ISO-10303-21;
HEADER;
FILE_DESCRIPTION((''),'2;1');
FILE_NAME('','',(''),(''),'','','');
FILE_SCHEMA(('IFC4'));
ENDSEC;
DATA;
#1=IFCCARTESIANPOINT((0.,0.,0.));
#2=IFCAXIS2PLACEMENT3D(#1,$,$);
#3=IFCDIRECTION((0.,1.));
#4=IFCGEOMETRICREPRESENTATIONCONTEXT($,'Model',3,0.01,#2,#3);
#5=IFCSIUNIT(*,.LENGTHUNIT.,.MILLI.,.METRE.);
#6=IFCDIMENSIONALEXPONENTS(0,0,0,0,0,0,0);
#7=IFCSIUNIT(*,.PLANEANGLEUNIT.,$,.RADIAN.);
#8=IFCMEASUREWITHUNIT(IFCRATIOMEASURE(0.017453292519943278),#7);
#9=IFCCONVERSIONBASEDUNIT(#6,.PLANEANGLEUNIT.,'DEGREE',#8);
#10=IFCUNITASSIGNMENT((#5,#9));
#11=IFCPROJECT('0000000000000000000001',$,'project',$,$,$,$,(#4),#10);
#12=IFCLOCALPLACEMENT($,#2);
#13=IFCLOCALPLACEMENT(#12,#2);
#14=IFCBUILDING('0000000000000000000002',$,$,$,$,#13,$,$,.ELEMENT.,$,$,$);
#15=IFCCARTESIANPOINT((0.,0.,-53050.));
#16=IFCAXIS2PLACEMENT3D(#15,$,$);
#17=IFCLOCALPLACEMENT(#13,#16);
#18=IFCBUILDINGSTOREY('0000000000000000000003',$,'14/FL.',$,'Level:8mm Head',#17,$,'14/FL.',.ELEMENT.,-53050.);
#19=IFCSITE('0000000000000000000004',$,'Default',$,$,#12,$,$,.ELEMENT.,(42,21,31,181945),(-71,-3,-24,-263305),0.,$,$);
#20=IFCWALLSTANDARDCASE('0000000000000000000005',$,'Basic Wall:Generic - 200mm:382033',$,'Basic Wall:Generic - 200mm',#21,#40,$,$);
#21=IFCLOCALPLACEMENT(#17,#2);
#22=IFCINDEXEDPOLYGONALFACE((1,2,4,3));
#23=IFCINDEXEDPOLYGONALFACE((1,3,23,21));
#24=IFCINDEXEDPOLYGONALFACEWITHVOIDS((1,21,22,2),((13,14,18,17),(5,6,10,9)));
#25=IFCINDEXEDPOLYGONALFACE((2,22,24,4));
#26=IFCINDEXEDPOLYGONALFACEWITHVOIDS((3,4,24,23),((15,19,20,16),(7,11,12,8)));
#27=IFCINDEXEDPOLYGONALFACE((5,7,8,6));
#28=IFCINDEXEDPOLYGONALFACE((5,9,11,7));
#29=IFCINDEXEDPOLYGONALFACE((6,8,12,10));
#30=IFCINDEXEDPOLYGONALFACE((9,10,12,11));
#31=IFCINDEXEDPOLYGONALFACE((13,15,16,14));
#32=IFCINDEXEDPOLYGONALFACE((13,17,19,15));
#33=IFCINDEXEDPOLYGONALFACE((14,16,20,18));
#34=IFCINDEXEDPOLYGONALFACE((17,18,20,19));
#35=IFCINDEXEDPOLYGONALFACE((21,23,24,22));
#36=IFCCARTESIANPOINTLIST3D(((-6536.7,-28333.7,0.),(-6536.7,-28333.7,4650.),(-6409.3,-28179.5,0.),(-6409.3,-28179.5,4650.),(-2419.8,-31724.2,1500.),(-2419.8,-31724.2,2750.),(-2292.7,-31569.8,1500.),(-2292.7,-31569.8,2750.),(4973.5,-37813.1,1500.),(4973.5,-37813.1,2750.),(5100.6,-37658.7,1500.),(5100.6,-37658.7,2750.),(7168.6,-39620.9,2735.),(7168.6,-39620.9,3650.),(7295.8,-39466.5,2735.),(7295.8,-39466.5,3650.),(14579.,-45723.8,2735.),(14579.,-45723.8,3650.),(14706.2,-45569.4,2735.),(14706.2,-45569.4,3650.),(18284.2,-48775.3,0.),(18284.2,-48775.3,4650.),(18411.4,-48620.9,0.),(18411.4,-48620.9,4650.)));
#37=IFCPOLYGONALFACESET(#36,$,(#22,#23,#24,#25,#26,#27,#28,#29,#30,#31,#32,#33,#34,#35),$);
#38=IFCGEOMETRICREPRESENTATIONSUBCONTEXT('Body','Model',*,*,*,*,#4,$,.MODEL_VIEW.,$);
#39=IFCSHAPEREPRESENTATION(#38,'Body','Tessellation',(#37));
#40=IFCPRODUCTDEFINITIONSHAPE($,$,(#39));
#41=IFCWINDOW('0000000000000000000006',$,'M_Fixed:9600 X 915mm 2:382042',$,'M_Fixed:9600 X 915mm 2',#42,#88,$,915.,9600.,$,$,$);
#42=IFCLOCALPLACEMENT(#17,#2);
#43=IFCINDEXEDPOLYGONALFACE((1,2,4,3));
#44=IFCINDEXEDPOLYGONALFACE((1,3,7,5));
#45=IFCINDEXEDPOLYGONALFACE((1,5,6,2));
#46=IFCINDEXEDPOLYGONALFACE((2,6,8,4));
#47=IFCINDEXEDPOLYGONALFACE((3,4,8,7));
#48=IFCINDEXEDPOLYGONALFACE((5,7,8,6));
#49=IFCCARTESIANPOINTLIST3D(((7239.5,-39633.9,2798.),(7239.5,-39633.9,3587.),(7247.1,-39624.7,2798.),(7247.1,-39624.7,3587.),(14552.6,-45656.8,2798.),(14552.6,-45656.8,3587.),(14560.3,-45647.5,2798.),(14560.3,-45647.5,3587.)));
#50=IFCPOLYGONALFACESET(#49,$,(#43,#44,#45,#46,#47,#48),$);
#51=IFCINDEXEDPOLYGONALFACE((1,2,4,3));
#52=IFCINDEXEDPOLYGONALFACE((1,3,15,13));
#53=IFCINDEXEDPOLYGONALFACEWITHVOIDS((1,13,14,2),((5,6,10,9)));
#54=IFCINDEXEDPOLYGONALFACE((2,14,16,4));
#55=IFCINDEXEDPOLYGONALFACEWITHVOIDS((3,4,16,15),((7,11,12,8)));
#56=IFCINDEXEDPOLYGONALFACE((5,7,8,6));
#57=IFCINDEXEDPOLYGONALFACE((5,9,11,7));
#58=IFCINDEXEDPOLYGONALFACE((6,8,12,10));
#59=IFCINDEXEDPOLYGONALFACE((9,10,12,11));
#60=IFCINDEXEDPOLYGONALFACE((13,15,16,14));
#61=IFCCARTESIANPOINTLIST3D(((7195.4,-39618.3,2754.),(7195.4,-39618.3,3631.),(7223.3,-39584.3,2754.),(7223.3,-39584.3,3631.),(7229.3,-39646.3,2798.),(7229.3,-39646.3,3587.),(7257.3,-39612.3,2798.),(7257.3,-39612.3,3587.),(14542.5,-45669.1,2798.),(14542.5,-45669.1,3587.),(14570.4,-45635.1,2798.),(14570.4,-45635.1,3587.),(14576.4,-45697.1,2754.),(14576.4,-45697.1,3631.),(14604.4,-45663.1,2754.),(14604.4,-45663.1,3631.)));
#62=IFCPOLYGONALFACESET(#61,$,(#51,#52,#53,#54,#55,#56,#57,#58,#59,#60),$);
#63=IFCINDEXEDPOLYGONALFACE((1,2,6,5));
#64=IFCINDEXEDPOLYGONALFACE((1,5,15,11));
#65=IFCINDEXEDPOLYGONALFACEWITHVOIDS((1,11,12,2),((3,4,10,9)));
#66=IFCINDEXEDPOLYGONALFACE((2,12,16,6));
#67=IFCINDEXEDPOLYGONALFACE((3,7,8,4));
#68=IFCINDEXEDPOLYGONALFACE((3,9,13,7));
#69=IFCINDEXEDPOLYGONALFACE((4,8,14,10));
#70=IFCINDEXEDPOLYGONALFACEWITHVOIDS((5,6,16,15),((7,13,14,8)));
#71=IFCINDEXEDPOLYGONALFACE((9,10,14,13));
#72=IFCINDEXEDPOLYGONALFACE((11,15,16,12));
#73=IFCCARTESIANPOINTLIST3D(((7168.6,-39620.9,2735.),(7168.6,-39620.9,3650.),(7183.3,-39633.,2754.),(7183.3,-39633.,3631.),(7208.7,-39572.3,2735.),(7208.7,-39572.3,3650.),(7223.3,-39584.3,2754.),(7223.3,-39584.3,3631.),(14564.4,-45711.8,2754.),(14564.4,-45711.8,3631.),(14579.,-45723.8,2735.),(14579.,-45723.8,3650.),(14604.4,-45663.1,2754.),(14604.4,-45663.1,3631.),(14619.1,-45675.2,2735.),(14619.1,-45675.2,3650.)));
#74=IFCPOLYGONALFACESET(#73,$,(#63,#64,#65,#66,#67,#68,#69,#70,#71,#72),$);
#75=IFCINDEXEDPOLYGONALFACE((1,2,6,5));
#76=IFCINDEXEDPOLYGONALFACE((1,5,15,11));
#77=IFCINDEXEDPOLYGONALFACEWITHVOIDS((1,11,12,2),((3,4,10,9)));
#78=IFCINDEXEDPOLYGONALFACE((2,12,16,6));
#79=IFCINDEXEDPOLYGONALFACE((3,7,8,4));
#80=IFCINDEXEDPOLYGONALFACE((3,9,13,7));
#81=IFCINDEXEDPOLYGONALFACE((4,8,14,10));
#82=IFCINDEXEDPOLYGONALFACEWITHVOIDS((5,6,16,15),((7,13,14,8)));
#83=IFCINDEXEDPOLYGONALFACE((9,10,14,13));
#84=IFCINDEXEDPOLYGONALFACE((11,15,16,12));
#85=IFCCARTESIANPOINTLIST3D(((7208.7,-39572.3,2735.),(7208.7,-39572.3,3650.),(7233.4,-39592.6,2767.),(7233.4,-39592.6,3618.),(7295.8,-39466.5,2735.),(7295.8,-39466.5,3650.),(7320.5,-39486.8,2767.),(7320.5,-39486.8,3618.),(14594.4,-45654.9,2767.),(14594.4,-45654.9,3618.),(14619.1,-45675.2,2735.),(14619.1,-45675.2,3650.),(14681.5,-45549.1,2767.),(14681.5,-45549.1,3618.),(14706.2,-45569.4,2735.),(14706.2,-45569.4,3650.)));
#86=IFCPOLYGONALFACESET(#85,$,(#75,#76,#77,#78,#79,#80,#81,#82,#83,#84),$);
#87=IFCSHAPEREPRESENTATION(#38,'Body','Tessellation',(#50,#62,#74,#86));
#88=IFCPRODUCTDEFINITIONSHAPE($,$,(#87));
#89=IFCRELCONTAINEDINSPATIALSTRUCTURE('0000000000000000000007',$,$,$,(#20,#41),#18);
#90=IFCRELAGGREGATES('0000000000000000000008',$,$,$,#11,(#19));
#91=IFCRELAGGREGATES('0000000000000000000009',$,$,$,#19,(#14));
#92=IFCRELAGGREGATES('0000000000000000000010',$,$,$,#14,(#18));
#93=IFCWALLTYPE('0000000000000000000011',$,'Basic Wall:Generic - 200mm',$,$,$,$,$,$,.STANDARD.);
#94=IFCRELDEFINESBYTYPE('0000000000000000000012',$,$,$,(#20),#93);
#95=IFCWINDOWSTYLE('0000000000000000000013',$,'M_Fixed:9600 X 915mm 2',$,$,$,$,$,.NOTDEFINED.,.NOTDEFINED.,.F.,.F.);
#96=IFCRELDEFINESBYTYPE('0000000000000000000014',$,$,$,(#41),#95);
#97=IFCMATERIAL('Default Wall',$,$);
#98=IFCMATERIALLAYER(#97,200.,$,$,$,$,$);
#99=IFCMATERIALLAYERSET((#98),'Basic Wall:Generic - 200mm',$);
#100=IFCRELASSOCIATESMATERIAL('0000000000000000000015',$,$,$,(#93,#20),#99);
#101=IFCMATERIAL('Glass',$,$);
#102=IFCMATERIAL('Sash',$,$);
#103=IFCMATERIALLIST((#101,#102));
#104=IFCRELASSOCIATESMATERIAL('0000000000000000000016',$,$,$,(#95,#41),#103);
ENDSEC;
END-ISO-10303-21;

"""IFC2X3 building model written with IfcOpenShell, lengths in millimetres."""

from ifc_helpers import new_model, entity, si_unit, converted_unit, direction, frame, frame_2d, origin, place, context, subcontext, project, spatial, polyline, rectangle, outline, extrude, source, transform, mapped, material, material_list, layer, layer_set, layer_usage, type_object, type_shapes, element, fill, save


model = new_model("IFC2X3")

# Units and contexts
model_context = context("Model", 3, precision=0.01, world=origin(), true_north=direction((0.0, 1.0)))
body_context = subcontext(model_context, "Body", "Model", "MODEL_VIEW")
ifc_project = project(units=[si_unit("LENGTHUNIT", "METRE", prefix="MILLI"), converted_unit("PLANEANGLEUNIT", "DEGREE", entity("IfcRatioMeasure", 0.017453292519943278), si_unit("PLANEANGLEUNIT", "RADIAN"), dimensions=[0, 0, 0, 0, 0, 0, 0])], contexts=[model_context])

# Site, building, storey
site_placement = place(None, origin())
site = spatial("IfcSite", under=ifc_project, at=site_placement, Name="Default", CompositionType="ELEMENT", RefLatitude=(42, 21, 31, 181945), RefLongitude=(-71, -3, -24, -263305), RefElevation=0.0)
building_placement = place(site_placement, origin())
building = spatial("IfcBuilding", under=site, at=building_placement, CompositionType="ELEMENT")
storey_placement = place(building_placement, frame((0.0, 0.0, -53050.0)))
storey = spatial("IfcBuildingStorey", under=building, at=storey_placement, Name="14/FL.", ObjectType="Level:8mm Head", LongName="14/FL.", CompositionType="ELEMENT", Elevation=-53050.0)

# Shared definitions
ifc_material_1 = material(Name="Default Wall")
ifc_layer = layer(ifc_material_1, 200.0)
ifc_layer_set = layer_set([ifc_layer], Name="Basic Wall:Generic - 200mm")
ifc_layer_usage = layer_usage(ifc_layer_set, "AXIS2", "NEGATIVE", 100.0)
wall_type = type_object("IfcWallType", Name="Basic Wall:Generic - 200mm", PredefinedType="STANDARD", material=ifc_layer_set)

# Shared definitions
ifc_material_2 = material(Name="Glass")
ifc_material_3 = material(Name="Sash")
ifc_material_list = material_list([ifc_material_2, ifc_material_3])

# Wall, openings, window
wall_1_placement = place(storey_placement, frame((-6473.1, -28256.5, 0.0), z_axis=(0.0, 0.0, 1.0), x_axis=(0.771917, -0.635723, 0.0)))
wall_1 = element("IfcWallStandardCase", 1, at=wall_1_placement, inside=storey, type_object=wall_type, material=ifc_layer_usage, Name="Basic Wall:Generic - 200mm:382033", ObjectType="Basic Wall:Generic - 200mm", context=body_context, shape_type="SweptSolid", body=[
    extrude(outline(polyline([(32154.9, -100.0), (32154.9, 100.0), (0.4, 100.0), (0.0, -100.0), (32154.9, -100.0)])), origin(), (0.0, 0.0, 1.0), 4650.0),
])
opening_1_placement = place(wall_1_placement, origin())
element("IfcOpeningElement", 2, at=opening_1_placement, cuts=wall_1, ObjectType="Opening", context=body_context, shape_type="SweptSolid", body=[
    extrude(rectangle(XDim=1250.0, YDim=9577.8, at=frame_2d((0.0, 0.0), x_axis=(1.0, 0.0))), frame((10122.3, -100.0, 2125.0), z_axis=(0.0, 1.0, 0.0), x_axis=(0.0, 0.0, -1.0)), (0.0, 0.0, 1.0), 200.0),
])
opening_2_placement = place(wall_1_placement, frame((-12966.6, 25926.8, 0.0), z_axis=(0.0, 0.0, 1.0), x_axis=(0.771917, 0.635723, 0.0)))
element("IfcOpeningElement", 3, at=opening_2_placement, cuts=wall_1, ObjectType="Opening", context=body_context, shape_type="SweptSolid", body=[
    extrude(rectangle(XDim=1000.0, YDim=1010.1, at=frame_2d((0.0, 0.0), x_axis=(1.0, 0.0))), frame((18666.0, -49106.2, 500.0), z_axis=(0.635723, 0.771917, 0.0), x_axis=(0.0, 0.0, -1.0)), (0.0, 0.0, 1.0), 1012.7),
])
opening_3_placement = place(wall_1_placement, frame((27354.9, 100.0, 2735.0)))
opening_3 = element("IfcOpeningElement", 4, at=opening_3_placement, cuts=wall_1, ObjectType="Opening", context=body_context, shape_type="SweptSolid", body=[
    extrude(rectangle(XDim=915.0, YDim=9600.0, at=frame_2d((457.5, 4800.0), x_axis=(1.0, 0.0))), frame((0.0, 0.0, 0.0), z_axis=(0.0, -1.0, 0.0), x_axis=(0.0, 0.0, 1.0)), (0.0, 0.0, 1.0), 200.0),
])
window_style_1 = type_object("IfcWindowStyle", Name="M_Fixed:9600 X 915mm 2", ConstructionType="NOTDEFINED", OperationType="NOTDEFINED", ParameterTakesPrecedence=False, Sizeable=False, material=ifc_material_list)
shared_shape_1 = source(origin(), body_context, "Body", "SweptSolid", [
    extrude(rectangle(XDim=12.0, YDim=9474.0, at=frame_2d((0.0, 0.0), x_axis=(1.0, 0.0))), frame((4800.0, 159.0, 63.0), z_axis=(0.0, 0.0, 1.0), x_axis=(0.0, -1.0, 0.0)), (0.0, 0.0, 1.0), 789.0),
    extrude(outline(polyline([(-4781.0, -438.5), (4781.0, -438.5), (4781.0, 438.5), (-4781.0, 438.5), (-4781.0, -438.5)]), holes=[polyline([(-4737.0, -394.5), (-4737.0, 394.5), (4737.0, 394.5), (4737.0, -394.5), (-4737.0, -394.5)])]), frame((4800.0, 137.0, 457.5), z_axis=(0.0, 1.0, 0.0), x_axis=(1.0, 0.0, 0.0)), (0.0, 0.0, 1.0), 44.0),
    extrude(outline(polyline([(-4800.0, -457.5), (4800.0, -457.5), (4800.0, 457.5), (-4800.0, 457.5), (-4800.0, -457.5)]), holes=[polyline([(-4781.0, -438.5), (-4781.0, 438.5), (4781.0, 438.5), (4781.0, -438.5), (-4781.0, -438.5)])]), frame((4800.0, 137.0, 457.5), z_axis=(0.0, 1.0, 0.0), x_axis=(1.0, 0.0, 0.0)), (0.0, 0.0, 1.0), 63.0),
    extrude(outline(polyline([(-4800.0, -457.5), (4800.0, -457.5), (4800.0, 457.5), (-4800.0, 457.5), (-4800.0, -457.5)]), holes=[polyline([(-4768.0, -425.5), (-4768.0, 425.5), (4768.0, 425.5), (4768.0, -425.5), (-4768.0, -425.5)])]), frame((4800.0, 0.0, 457.5), z_axis=(0.0, 1.0, 0.0), x_axis=(1.0, 0.0, 0.0)), (0.0, 0.0, 1.0), 137.0),
])
type_shapes(window_style_1, [shared_shape_1])
window_1_placement = place(opening_3_placement, frame((0.0, 0.0, 0.0), z_axis=(0.0, 0.0, 1.0), x_axis=(-1.0, 0.0, 0.0)))
window_1 = element("IfcWindow", 5, at=window_1_placement, inside=storey, type_object=window_style_1, material=ifc_material_list, Name="M_Fixed:9600 X 915mm 2:382042", ObjectType="M_Fixed:9600 X 915mm 2", OverallHeight=915.0, OverallWidth=9600.0, context=body_context, shape_type="MappedRepresentation", body=[
    mapped(shared_shape_1, transform((0.0, 0.0, 0.0), scale=1.0)),
])
fill(opening_3, window_1)

save(model, "model.ifc")
